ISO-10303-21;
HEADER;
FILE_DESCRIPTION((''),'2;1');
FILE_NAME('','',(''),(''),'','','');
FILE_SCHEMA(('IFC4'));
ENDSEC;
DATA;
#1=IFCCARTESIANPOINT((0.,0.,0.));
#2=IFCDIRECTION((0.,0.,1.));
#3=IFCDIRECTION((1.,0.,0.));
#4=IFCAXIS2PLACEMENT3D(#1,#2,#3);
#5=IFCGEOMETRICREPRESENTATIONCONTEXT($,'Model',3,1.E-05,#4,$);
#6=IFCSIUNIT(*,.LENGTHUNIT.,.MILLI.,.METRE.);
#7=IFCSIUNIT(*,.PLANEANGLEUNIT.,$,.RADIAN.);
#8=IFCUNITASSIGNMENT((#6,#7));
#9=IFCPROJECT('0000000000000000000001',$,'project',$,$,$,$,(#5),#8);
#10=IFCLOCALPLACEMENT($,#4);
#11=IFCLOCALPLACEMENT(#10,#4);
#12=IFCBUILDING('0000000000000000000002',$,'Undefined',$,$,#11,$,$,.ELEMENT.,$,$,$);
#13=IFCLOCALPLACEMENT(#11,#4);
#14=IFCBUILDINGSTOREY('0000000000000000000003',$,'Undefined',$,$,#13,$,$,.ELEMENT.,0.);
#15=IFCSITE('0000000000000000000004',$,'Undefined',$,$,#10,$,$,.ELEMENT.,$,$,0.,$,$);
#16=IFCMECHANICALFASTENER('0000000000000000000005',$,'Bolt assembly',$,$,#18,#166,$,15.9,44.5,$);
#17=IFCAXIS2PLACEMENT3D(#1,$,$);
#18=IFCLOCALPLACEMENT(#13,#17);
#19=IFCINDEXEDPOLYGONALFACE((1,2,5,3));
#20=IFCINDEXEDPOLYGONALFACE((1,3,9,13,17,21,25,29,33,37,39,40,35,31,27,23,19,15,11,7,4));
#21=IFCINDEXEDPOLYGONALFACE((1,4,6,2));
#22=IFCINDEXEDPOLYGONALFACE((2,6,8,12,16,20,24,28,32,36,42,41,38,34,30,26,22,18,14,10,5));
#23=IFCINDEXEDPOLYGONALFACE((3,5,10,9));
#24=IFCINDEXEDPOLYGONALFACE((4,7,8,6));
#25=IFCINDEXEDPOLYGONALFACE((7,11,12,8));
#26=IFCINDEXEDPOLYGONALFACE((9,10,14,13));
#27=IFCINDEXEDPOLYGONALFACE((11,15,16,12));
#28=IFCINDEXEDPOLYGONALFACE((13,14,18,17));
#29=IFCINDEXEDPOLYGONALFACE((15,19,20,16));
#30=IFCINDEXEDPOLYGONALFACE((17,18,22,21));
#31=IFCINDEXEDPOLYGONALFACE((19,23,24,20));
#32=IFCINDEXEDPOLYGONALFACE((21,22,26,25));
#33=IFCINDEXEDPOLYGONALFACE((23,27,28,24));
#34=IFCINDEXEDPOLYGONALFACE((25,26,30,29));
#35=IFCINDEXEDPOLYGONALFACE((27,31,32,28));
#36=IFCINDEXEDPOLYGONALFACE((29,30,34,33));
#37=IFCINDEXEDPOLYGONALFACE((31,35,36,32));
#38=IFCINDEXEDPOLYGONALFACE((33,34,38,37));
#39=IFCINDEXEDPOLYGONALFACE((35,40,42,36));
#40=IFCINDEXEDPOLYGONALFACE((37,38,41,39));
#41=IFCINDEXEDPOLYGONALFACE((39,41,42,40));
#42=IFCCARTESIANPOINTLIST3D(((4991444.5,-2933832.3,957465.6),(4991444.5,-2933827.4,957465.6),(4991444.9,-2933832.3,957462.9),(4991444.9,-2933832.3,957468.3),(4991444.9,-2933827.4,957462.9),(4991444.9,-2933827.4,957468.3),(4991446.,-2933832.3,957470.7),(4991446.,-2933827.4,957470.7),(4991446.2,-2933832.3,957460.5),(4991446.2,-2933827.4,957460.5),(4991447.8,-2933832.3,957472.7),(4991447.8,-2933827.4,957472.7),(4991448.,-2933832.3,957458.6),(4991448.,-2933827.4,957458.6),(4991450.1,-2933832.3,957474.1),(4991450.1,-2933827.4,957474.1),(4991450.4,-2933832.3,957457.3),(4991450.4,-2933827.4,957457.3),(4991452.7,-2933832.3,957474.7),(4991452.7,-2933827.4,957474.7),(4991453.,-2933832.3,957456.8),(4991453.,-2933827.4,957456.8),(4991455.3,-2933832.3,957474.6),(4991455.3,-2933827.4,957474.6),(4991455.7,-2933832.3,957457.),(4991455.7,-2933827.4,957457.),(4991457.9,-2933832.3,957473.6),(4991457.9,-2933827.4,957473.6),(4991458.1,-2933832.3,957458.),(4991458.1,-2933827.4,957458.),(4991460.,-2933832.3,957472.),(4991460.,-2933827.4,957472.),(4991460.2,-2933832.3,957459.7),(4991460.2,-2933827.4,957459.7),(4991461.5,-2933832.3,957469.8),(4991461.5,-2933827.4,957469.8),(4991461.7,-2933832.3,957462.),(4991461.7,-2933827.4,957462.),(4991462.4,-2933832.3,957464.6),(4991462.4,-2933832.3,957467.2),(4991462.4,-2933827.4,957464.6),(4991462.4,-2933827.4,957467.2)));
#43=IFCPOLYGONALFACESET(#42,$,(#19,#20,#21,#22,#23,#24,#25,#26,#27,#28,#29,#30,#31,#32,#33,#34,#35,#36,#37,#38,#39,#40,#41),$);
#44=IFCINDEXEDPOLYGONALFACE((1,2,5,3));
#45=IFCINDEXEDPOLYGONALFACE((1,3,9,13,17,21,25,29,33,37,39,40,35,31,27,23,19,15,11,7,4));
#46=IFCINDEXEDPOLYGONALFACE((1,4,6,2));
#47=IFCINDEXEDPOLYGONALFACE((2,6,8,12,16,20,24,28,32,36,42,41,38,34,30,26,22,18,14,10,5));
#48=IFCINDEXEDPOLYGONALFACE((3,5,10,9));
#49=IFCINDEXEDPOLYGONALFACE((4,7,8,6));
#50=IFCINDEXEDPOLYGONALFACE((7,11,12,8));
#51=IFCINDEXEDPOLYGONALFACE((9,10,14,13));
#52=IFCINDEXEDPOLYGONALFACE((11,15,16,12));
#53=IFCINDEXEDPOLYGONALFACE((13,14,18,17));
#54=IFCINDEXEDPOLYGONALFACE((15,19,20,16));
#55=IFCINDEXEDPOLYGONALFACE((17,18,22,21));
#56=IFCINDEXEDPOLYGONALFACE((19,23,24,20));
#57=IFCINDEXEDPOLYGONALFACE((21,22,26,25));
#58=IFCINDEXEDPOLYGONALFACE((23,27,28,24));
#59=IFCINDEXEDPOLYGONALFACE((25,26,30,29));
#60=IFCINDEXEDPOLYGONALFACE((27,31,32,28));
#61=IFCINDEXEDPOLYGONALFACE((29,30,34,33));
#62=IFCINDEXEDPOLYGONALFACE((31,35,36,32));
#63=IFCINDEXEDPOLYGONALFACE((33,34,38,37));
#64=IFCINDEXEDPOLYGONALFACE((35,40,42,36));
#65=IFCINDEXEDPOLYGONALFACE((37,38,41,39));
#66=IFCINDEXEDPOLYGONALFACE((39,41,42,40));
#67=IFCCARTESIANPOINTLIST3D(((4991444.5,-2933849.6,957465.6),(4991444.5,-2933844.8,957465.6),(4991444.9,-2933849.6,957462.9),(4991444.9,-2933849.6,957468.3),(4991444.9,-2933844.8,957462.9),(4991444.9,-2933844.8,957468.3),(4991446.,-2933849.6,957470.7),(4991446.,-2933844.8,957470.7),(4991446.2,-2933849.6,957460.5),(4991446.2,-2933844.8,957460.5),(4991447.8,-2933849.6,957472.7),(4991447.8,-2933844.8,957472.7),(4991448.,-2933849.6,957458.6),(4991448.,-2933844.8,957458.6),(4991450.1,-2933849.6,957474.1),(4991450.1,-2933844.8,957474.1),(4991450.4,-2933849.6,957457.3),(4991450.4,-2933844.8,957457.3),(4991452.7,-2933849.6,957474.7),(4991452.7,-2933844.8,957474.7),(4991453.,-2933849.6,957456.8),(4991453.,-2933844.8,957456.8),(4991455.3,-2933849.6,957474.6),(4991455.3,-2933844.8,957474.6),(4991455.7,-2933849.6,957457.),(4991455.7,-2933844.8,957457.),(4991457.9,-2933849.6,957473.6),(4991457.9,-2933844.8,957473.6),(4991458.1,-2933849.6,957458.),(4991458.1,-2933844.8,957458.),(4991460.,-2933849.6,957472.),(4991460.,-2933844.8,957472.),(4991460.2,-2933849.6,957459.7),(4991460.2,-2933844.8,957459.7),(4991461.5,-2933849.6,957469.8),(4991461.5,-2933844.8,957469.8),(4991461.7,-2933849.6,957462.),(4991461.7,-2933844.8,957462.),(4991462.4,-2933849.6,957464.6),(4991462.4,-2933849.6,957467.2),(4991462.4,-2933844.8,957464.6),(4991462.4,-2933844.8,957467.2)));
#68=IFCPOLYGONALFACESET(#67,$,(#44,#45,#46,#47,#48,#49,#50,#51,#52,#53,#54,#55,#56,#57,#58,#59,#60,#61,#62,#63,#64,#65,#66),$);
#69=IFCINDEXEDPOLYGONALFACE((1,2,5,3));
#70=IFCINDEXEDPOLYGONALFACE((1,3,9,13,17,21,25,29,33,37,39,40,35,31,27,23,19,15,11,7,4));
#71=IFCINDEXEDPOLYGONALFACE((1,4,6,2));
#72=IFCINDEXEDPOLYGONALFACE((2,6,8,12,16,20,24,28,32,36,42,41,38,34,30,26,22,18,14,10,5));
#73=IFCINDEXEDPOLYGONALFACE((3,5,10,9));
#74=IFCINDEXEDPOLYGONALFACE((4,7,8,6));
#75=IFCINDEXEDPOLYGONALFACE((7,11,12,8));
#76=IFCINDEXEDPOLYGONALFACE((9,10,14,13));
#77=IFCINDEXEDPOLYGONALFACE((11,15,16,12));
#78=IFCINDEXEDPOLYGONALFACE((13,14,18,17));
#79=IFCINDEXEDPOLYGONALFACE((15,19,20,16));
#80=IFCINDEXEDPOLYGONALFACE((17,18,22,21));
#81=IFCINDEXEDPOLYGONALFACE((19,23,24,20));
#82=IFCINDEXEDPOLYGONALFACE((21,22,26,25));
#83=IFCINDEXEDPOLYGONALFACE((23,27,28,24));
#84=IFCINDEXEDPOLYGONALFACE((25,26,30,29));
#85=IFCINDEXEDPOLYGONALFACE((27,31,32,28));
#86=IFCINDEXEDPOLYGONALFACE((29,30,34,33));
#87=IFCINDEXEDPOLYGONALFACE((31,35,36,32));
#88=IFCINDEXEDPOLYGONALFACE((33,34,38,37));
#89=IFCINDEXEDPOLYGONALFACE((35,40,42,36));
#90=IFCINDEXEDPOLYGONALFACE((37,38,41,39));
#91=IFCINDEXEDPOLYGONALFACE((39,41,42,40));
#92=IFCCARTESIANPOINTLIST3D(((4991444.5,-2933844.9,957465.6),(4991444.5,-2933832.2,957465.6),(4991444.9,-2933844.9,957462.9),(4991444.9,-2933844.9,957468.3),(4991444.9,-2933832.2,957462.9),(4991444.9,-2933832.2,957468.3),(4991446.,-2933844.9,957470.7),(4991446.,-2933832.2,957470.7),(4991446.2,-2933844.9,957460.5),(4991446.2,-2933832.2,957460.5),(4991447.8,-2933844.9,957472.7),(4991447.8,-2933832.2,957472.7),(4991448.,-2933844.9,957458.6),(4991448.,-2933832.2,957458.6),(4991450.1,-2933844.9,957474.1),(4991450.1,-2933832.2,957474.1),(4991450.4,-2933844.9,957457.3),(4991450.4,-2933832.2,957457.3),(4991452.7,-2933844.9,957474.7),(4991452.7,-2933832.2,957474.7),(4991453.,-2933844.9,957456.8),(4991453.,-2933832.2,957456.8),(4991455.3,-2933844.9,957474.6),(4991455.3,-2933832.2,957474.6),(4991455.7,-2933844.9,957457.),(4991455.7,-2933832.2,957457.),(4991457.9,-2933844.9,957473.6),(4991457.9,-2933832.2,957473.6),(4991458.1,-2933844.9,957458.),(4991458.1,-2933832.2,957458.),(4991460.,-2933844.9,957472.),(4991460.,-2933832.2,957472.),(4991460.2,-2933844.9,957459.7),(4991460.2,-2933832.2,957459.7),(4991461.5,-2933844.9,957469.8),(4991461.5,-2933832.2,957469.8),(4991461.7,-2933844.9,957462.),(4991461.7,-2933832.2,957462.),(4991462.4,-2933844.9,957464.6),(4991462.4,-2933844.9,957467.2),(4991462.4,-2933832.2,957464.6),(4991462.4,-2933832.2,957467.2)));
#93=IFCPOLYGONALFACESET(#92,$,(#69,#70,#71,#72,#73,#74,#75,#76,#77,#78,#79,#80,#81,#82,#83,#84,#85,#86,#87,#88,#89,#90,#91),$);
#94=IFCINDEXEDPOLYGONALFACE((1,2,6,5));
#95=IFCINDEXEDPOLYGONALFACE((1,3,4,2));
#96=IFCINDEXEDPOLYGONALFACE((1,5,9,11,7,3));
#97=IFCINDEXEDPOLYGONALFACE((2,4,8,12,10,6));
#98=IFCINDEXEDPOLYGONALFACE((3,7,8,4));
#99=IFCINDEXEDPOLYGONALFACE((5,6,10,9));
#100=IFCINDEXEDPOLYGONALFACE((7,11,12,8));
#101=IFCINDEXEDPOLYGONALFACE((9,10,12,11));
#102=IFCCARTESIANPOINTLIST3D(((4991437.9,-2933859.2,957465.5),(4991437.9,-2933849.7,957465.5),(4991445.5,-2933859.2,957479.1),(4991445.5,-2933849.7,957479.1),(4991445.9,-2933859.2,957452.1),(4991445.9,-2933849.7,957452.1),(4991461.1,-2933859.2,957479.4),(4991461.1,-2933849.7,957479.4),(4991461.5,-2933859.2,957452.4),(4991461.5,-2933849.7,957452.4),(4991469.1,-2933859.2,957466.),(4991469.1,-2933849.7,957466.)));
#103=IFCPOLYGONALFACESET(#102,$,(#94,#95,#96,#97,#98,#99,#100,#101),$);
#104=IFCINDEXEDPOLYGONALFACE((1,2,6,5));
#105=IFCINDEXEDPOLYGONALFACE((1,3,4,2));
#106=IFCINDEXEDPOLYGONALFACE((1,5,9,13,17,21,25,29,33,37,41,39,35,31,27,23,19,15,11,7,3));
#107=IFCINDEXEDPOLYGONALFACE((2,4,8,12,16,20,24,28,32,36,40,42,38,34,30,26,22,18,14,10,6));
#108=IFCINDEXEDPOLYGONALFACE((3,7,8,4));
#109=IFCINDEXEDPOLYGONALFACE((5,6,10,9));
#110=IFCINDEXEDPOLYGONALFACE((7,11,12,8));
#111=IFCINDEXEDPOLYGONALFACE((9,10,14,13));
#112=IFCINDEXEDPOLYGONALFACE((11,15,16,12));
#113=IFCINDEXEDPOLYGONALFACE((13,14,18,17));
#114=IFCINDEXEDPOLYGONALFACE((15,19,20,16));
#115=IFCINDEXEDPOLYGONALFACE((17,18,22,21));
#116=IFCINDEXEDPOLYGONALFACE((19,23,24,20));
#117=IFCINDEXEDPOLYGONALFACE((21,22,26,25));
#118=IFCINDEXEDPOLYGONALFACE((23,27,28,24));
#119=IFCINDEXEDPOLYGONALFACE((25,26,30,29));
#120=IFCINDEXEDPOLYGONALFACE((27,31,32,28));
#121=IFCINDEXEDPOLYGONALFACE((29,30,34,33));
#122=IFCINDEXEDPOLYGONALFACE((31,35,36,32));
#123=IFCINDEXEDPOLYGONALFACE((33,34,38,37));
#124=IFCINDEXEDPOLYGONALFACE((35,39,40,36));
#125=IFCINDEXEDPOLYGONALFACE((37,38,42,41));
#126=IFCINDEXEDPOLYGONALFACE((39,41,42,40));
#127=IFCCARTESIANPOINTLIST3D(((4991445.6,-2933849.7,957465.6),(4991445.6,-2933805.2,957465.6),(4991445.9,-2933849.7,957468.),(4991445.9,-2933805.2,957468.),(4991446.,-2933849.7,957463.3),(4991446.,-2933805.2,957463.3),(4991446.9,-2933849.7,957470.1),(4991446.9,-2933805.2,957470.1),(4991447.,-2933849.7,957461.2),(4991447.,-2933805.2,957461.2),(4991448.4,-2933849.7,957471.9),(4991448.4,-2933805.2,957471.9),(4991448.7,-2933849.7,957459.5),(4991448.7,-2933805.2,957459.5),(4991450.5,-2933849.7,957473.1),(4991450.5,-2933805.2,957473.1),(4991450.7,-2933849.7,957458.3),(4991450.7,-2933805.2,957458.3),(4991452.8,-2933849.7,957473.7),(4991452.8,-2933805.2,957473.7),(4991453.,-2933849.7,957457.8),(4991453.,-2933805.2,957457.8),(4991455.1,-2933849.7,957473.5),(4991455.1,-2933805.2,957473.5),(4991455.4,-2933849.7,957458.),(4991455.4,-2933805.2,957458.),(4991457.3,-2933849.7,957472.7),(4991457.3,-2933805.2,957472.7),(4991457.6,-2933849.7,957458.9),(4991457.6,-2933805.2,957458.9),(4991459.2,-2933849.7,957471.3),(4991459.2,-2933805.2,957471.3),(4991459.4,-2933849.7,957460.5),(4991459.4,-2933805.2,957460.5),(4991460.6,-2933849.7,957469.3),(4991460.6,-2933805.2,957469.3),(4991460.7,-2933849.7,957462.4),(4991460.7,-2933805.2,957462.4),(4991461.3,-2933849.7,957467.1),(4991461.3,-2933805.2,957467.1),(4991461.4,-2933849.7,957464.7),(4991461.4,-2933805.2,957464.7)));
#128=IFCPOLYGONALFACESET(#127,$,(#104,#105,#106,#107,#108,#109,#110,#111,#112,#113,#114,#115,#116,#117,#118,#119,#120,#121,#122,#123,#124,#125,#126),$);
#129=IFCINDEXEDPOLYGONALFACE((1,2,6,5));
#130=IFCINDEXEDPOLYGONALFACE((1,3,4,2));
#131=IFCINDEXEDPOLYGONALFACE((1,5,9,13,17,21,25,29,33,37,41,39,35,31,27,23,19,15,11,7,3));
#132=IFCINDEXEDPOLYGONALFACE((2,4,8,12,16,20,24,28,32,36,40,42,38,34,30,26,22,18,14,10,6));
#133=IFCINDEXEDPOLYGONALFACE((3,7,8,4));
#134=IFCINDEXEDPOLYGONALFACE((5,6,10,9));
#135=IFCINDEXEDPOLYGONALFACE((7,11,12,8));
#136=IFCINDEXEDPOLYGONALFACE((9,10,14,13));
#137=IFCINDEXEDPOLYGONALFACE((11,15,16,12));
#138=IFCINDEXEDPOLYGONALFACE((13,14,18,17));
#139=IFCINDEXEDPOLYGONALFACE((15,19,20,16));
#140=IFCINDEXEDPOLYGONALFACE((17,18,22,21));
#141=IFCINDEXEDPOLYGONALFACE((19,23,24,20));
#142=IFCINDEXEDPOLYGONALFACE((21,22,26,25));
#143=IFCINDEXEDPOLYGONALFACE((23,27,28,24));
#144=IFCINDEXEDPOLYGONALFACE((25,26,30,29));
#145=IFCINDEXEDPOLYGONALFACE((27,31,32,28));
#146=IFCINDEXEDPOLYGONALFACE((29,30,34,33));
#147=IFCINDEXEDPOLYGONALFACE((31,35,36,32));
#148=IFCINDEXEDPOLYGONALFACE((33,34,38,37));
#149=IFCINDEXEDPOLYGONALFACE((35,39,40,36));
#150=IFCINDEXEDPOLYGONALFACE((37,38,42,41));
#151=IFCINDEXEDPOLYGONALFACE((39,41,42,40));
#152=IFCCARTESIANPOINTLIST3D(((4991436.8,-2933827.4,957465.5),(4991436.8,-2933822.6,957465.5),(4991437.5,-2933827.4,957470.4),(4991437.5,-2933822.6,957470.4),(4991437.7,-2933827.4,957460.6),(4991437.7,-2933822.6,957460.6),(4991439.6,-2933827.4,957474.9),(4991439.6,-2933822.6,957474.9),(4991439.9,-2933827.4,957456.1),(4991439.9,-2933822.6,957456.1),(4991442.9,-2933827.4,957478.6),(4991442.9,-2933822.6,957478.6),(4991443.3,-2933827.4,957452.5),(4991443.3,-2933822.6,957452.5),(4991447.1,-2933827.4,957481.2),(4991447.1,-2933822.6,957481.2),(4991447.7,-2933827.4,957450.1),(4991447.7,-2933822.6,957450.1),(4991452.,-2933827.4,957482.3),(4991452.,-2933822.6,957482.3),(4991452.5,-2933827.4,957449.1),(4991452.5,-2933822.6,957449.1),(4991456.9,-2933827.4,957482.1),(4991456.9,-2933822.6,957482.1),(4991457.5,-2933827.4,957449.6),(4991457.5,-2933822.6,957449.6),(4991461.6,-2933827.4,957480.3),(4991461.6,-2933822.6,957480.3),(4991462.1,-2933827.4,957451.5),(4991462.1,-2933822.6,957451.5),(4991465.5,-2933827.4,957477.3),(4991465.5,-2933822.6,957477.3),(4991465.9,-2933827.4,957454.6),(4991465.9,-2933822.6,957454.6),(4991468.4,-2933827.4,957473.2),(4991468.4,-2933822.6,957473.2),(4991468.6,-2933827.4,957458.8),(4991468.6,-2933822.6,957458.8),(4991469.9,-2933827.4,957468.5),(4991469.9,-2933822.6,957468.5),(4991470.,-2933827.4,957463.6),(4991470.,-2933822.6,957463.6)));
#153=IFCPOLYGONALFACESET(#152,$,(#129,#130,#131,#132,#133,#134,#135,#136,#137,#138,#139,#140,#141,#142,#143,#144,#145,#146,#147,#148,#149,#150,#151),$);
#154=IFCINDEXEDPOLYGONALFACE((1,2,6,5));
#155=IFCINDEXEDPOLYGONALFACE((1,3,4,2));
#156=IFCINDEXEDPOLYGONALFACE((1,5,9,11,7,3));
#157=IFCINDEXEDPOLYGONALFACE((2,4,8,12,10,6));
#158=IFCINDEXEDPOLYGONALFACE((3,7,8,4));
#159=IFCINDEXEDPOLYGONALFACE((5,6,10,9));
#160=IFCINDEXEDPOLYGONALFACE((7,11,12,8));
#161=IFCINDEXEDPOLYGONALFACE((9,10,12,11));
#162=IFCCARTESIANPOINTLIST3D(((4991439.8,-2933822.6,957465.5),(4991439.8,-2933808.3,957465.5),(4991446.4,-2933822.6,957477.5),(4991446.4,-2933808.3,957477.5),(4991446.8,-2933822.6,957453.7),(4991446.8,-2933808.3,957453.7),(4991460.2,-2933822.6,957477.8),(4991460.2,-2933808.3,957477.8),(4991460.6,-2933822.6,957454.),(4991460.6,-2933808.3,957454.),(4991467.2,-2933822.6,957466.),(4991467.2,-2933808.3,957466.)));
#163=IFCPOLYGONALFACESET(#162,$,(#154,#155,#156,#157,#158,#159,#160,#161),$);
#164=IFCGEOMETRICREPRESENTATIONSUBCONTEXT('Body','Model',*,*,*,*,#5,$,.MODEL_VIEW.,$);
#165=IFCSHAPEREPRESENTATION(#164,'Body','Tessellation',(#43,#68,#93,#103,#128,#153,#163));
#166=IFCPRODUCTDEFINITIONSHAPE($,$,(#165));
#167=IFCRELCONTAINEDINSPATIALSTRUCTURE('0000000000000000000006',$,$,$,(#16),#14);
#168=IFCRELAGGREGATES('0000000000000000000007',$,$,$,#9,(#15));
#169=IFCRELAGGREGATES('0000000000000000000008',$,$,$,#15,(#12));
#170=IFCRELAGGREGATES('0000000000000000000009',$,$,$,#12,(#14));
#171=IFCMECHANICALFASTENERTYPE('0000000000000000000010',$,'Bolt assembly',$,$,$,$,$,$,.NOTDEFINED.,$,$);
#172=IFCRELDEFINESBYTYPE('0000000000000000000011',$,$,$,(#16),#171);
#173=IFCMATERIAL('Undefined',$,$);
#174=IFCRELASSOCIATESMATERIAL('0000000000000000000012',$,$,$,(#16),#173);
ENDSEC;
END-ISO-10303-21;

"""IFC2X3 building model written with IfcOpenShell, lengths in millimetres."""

from ifc_helpers import new_model, si_unit, frame, origin_with_axes, origin_2d_with_axis, place, context, subcontext, project, spatial, polyline, circle, outline, extrude, source, transform, mapped, material, type_object, element, save


model = new_model("IFC2X3")

# Units and contexts
model_context = context("Model", 3, precision=1e-05, world=origin_with_axes())
body_context = subcontext(model_context, "Body", "Model", "MODEL_VIEW")
ifc_project = project(units=[si_unit("LENGTHUNIT", "METRE", prefix="MILLI"), si_unit("PLANEANGLEUNIT", "RADIAN")], contexts=[model_context])

# Site, building, storey
site_placement = place(None, origin_with_axes())
site = spatial("IfcSite", under=ifc_project, at=site_placement, Name="Undefined", CompositionType="ELEMENT", RefElevation=0.0)
building_placement = place(site_placement, origin_with_axes())
building = spatial("IfcBuilding", under=site, at=building_placement, Name="Undefined", CompositionType="ELEMENT")
storey_placement = place(building_placement, origin_with_axes())
storey = spatial("IfcBuildingStorey", under=building, at=storey_placement, Name="Undefined", CompositionType="ELEMENT", Elevation=0.0)

# Shared definitions
ifc_material_1 = material(Name="Undefined")
mechanical_fastener_type = type_object("IfcMechanicalFastenerType", Name="Bolt assembly")

# Mechanical fastener
shared_shape_1 = source(origin_with_axes(), body_context, "Body", "SweptSolid", [
    extrude(circle(Radius=9.0, at=origin_2d_with_axis()), frame((0.0, 6.3, 0.0), z_axis=(0.0, 1.0, 0.0), x_axis=(1.0, 0.0, 0.0)), (0.0, 0.0, 1.0), 4.9),
    extrude(circle(Radius=9.0, at=origin_2d_with_axis()), frame((0.0, -11.0, 0.0), z_axis=(0.0, 1.0, 0.0), x_axis=(1.0, 0.0, 0.0)), (0.0, 0.0, 1.0), 4.8),
    extrude(circle(Radius=9.0, at=origin_2d_with_axis()), frame((0.0, -6.4, 0.0), z_axis=(0.0, 1.0, 0.0), x_axis=(1.0, 0.0, 0.0)), (0.0, 0.0, 1.0), 12.7),
    extrude(outline(polyline([(15.6, 0.0), (7.8, 13.5), (-7.8, 13.5), (-15.6, 0.0), (-7.8, -13.5), (7.8, -13.5), (15.6, 0.0)])), frame((0.0, -20.7, 0.0), z_axis=(0.0, 1.0, 0.0), x_axis=(1.0, 0.0, 0.0)), (0.0, 0.0, 1.0), 9.5),
    extrude(circle(Radius=7.9, at=origin_2d_with_axis()), frame((0.0, -11.1, 0.0), z_axis=(0.0, 1.0, 0.0), x_axis=(1.0, 0.0, 0.0)), (0.0, 0.0, 1.0), 44.5),
    extrude(circle(Radius=16.7, at=origin_2d_with_axis()), frame((0.0, 11.1, 0.0), z_axis=(0.0, 1.0, 0.0), x_axis=(1.0, 0.0, 0.0)), (0.0, 0.0, 1.0), 4.8),
    extrude(outline(polyline([(13.7, 0.0), (6.9, 11.9), (-6.9, 11.9), (-13.7, 0.0), (-6.9, -11.9), (6.9, -11.9), (13.7, 0.0)])), frame((0.0, 15.9, 0.0), z_axis=(0.0, 1.0, 0.0), x_axis=(1.0, 0.0, 0.0)), (0.0, 0.0, 1.0), 14.3),
])
mechanical_fastener_1_placement = place(storey_placement, frame((4991453.5, -2933838.5, 957465.8), z_axis=(-0.874698, 0.0, 0.484667), x_axis=(0.484667, 0.0, 0.874698)))
element("IfcMechanicalFastener", 1, at=mechanical_fastener_1_placement, inside=storey, type_object=mechanical_fastener_type, material=ifc_material_1, Name="Bolt assembly", NominalDiameter=15.9, NominalLength=44.5, context=body_context, shape_type="MappedRepresentation", body=[
    mapped(shared_shape_1, transform((0.0, 0.0, 0.0))),
])

save(model, "model.ifc")
